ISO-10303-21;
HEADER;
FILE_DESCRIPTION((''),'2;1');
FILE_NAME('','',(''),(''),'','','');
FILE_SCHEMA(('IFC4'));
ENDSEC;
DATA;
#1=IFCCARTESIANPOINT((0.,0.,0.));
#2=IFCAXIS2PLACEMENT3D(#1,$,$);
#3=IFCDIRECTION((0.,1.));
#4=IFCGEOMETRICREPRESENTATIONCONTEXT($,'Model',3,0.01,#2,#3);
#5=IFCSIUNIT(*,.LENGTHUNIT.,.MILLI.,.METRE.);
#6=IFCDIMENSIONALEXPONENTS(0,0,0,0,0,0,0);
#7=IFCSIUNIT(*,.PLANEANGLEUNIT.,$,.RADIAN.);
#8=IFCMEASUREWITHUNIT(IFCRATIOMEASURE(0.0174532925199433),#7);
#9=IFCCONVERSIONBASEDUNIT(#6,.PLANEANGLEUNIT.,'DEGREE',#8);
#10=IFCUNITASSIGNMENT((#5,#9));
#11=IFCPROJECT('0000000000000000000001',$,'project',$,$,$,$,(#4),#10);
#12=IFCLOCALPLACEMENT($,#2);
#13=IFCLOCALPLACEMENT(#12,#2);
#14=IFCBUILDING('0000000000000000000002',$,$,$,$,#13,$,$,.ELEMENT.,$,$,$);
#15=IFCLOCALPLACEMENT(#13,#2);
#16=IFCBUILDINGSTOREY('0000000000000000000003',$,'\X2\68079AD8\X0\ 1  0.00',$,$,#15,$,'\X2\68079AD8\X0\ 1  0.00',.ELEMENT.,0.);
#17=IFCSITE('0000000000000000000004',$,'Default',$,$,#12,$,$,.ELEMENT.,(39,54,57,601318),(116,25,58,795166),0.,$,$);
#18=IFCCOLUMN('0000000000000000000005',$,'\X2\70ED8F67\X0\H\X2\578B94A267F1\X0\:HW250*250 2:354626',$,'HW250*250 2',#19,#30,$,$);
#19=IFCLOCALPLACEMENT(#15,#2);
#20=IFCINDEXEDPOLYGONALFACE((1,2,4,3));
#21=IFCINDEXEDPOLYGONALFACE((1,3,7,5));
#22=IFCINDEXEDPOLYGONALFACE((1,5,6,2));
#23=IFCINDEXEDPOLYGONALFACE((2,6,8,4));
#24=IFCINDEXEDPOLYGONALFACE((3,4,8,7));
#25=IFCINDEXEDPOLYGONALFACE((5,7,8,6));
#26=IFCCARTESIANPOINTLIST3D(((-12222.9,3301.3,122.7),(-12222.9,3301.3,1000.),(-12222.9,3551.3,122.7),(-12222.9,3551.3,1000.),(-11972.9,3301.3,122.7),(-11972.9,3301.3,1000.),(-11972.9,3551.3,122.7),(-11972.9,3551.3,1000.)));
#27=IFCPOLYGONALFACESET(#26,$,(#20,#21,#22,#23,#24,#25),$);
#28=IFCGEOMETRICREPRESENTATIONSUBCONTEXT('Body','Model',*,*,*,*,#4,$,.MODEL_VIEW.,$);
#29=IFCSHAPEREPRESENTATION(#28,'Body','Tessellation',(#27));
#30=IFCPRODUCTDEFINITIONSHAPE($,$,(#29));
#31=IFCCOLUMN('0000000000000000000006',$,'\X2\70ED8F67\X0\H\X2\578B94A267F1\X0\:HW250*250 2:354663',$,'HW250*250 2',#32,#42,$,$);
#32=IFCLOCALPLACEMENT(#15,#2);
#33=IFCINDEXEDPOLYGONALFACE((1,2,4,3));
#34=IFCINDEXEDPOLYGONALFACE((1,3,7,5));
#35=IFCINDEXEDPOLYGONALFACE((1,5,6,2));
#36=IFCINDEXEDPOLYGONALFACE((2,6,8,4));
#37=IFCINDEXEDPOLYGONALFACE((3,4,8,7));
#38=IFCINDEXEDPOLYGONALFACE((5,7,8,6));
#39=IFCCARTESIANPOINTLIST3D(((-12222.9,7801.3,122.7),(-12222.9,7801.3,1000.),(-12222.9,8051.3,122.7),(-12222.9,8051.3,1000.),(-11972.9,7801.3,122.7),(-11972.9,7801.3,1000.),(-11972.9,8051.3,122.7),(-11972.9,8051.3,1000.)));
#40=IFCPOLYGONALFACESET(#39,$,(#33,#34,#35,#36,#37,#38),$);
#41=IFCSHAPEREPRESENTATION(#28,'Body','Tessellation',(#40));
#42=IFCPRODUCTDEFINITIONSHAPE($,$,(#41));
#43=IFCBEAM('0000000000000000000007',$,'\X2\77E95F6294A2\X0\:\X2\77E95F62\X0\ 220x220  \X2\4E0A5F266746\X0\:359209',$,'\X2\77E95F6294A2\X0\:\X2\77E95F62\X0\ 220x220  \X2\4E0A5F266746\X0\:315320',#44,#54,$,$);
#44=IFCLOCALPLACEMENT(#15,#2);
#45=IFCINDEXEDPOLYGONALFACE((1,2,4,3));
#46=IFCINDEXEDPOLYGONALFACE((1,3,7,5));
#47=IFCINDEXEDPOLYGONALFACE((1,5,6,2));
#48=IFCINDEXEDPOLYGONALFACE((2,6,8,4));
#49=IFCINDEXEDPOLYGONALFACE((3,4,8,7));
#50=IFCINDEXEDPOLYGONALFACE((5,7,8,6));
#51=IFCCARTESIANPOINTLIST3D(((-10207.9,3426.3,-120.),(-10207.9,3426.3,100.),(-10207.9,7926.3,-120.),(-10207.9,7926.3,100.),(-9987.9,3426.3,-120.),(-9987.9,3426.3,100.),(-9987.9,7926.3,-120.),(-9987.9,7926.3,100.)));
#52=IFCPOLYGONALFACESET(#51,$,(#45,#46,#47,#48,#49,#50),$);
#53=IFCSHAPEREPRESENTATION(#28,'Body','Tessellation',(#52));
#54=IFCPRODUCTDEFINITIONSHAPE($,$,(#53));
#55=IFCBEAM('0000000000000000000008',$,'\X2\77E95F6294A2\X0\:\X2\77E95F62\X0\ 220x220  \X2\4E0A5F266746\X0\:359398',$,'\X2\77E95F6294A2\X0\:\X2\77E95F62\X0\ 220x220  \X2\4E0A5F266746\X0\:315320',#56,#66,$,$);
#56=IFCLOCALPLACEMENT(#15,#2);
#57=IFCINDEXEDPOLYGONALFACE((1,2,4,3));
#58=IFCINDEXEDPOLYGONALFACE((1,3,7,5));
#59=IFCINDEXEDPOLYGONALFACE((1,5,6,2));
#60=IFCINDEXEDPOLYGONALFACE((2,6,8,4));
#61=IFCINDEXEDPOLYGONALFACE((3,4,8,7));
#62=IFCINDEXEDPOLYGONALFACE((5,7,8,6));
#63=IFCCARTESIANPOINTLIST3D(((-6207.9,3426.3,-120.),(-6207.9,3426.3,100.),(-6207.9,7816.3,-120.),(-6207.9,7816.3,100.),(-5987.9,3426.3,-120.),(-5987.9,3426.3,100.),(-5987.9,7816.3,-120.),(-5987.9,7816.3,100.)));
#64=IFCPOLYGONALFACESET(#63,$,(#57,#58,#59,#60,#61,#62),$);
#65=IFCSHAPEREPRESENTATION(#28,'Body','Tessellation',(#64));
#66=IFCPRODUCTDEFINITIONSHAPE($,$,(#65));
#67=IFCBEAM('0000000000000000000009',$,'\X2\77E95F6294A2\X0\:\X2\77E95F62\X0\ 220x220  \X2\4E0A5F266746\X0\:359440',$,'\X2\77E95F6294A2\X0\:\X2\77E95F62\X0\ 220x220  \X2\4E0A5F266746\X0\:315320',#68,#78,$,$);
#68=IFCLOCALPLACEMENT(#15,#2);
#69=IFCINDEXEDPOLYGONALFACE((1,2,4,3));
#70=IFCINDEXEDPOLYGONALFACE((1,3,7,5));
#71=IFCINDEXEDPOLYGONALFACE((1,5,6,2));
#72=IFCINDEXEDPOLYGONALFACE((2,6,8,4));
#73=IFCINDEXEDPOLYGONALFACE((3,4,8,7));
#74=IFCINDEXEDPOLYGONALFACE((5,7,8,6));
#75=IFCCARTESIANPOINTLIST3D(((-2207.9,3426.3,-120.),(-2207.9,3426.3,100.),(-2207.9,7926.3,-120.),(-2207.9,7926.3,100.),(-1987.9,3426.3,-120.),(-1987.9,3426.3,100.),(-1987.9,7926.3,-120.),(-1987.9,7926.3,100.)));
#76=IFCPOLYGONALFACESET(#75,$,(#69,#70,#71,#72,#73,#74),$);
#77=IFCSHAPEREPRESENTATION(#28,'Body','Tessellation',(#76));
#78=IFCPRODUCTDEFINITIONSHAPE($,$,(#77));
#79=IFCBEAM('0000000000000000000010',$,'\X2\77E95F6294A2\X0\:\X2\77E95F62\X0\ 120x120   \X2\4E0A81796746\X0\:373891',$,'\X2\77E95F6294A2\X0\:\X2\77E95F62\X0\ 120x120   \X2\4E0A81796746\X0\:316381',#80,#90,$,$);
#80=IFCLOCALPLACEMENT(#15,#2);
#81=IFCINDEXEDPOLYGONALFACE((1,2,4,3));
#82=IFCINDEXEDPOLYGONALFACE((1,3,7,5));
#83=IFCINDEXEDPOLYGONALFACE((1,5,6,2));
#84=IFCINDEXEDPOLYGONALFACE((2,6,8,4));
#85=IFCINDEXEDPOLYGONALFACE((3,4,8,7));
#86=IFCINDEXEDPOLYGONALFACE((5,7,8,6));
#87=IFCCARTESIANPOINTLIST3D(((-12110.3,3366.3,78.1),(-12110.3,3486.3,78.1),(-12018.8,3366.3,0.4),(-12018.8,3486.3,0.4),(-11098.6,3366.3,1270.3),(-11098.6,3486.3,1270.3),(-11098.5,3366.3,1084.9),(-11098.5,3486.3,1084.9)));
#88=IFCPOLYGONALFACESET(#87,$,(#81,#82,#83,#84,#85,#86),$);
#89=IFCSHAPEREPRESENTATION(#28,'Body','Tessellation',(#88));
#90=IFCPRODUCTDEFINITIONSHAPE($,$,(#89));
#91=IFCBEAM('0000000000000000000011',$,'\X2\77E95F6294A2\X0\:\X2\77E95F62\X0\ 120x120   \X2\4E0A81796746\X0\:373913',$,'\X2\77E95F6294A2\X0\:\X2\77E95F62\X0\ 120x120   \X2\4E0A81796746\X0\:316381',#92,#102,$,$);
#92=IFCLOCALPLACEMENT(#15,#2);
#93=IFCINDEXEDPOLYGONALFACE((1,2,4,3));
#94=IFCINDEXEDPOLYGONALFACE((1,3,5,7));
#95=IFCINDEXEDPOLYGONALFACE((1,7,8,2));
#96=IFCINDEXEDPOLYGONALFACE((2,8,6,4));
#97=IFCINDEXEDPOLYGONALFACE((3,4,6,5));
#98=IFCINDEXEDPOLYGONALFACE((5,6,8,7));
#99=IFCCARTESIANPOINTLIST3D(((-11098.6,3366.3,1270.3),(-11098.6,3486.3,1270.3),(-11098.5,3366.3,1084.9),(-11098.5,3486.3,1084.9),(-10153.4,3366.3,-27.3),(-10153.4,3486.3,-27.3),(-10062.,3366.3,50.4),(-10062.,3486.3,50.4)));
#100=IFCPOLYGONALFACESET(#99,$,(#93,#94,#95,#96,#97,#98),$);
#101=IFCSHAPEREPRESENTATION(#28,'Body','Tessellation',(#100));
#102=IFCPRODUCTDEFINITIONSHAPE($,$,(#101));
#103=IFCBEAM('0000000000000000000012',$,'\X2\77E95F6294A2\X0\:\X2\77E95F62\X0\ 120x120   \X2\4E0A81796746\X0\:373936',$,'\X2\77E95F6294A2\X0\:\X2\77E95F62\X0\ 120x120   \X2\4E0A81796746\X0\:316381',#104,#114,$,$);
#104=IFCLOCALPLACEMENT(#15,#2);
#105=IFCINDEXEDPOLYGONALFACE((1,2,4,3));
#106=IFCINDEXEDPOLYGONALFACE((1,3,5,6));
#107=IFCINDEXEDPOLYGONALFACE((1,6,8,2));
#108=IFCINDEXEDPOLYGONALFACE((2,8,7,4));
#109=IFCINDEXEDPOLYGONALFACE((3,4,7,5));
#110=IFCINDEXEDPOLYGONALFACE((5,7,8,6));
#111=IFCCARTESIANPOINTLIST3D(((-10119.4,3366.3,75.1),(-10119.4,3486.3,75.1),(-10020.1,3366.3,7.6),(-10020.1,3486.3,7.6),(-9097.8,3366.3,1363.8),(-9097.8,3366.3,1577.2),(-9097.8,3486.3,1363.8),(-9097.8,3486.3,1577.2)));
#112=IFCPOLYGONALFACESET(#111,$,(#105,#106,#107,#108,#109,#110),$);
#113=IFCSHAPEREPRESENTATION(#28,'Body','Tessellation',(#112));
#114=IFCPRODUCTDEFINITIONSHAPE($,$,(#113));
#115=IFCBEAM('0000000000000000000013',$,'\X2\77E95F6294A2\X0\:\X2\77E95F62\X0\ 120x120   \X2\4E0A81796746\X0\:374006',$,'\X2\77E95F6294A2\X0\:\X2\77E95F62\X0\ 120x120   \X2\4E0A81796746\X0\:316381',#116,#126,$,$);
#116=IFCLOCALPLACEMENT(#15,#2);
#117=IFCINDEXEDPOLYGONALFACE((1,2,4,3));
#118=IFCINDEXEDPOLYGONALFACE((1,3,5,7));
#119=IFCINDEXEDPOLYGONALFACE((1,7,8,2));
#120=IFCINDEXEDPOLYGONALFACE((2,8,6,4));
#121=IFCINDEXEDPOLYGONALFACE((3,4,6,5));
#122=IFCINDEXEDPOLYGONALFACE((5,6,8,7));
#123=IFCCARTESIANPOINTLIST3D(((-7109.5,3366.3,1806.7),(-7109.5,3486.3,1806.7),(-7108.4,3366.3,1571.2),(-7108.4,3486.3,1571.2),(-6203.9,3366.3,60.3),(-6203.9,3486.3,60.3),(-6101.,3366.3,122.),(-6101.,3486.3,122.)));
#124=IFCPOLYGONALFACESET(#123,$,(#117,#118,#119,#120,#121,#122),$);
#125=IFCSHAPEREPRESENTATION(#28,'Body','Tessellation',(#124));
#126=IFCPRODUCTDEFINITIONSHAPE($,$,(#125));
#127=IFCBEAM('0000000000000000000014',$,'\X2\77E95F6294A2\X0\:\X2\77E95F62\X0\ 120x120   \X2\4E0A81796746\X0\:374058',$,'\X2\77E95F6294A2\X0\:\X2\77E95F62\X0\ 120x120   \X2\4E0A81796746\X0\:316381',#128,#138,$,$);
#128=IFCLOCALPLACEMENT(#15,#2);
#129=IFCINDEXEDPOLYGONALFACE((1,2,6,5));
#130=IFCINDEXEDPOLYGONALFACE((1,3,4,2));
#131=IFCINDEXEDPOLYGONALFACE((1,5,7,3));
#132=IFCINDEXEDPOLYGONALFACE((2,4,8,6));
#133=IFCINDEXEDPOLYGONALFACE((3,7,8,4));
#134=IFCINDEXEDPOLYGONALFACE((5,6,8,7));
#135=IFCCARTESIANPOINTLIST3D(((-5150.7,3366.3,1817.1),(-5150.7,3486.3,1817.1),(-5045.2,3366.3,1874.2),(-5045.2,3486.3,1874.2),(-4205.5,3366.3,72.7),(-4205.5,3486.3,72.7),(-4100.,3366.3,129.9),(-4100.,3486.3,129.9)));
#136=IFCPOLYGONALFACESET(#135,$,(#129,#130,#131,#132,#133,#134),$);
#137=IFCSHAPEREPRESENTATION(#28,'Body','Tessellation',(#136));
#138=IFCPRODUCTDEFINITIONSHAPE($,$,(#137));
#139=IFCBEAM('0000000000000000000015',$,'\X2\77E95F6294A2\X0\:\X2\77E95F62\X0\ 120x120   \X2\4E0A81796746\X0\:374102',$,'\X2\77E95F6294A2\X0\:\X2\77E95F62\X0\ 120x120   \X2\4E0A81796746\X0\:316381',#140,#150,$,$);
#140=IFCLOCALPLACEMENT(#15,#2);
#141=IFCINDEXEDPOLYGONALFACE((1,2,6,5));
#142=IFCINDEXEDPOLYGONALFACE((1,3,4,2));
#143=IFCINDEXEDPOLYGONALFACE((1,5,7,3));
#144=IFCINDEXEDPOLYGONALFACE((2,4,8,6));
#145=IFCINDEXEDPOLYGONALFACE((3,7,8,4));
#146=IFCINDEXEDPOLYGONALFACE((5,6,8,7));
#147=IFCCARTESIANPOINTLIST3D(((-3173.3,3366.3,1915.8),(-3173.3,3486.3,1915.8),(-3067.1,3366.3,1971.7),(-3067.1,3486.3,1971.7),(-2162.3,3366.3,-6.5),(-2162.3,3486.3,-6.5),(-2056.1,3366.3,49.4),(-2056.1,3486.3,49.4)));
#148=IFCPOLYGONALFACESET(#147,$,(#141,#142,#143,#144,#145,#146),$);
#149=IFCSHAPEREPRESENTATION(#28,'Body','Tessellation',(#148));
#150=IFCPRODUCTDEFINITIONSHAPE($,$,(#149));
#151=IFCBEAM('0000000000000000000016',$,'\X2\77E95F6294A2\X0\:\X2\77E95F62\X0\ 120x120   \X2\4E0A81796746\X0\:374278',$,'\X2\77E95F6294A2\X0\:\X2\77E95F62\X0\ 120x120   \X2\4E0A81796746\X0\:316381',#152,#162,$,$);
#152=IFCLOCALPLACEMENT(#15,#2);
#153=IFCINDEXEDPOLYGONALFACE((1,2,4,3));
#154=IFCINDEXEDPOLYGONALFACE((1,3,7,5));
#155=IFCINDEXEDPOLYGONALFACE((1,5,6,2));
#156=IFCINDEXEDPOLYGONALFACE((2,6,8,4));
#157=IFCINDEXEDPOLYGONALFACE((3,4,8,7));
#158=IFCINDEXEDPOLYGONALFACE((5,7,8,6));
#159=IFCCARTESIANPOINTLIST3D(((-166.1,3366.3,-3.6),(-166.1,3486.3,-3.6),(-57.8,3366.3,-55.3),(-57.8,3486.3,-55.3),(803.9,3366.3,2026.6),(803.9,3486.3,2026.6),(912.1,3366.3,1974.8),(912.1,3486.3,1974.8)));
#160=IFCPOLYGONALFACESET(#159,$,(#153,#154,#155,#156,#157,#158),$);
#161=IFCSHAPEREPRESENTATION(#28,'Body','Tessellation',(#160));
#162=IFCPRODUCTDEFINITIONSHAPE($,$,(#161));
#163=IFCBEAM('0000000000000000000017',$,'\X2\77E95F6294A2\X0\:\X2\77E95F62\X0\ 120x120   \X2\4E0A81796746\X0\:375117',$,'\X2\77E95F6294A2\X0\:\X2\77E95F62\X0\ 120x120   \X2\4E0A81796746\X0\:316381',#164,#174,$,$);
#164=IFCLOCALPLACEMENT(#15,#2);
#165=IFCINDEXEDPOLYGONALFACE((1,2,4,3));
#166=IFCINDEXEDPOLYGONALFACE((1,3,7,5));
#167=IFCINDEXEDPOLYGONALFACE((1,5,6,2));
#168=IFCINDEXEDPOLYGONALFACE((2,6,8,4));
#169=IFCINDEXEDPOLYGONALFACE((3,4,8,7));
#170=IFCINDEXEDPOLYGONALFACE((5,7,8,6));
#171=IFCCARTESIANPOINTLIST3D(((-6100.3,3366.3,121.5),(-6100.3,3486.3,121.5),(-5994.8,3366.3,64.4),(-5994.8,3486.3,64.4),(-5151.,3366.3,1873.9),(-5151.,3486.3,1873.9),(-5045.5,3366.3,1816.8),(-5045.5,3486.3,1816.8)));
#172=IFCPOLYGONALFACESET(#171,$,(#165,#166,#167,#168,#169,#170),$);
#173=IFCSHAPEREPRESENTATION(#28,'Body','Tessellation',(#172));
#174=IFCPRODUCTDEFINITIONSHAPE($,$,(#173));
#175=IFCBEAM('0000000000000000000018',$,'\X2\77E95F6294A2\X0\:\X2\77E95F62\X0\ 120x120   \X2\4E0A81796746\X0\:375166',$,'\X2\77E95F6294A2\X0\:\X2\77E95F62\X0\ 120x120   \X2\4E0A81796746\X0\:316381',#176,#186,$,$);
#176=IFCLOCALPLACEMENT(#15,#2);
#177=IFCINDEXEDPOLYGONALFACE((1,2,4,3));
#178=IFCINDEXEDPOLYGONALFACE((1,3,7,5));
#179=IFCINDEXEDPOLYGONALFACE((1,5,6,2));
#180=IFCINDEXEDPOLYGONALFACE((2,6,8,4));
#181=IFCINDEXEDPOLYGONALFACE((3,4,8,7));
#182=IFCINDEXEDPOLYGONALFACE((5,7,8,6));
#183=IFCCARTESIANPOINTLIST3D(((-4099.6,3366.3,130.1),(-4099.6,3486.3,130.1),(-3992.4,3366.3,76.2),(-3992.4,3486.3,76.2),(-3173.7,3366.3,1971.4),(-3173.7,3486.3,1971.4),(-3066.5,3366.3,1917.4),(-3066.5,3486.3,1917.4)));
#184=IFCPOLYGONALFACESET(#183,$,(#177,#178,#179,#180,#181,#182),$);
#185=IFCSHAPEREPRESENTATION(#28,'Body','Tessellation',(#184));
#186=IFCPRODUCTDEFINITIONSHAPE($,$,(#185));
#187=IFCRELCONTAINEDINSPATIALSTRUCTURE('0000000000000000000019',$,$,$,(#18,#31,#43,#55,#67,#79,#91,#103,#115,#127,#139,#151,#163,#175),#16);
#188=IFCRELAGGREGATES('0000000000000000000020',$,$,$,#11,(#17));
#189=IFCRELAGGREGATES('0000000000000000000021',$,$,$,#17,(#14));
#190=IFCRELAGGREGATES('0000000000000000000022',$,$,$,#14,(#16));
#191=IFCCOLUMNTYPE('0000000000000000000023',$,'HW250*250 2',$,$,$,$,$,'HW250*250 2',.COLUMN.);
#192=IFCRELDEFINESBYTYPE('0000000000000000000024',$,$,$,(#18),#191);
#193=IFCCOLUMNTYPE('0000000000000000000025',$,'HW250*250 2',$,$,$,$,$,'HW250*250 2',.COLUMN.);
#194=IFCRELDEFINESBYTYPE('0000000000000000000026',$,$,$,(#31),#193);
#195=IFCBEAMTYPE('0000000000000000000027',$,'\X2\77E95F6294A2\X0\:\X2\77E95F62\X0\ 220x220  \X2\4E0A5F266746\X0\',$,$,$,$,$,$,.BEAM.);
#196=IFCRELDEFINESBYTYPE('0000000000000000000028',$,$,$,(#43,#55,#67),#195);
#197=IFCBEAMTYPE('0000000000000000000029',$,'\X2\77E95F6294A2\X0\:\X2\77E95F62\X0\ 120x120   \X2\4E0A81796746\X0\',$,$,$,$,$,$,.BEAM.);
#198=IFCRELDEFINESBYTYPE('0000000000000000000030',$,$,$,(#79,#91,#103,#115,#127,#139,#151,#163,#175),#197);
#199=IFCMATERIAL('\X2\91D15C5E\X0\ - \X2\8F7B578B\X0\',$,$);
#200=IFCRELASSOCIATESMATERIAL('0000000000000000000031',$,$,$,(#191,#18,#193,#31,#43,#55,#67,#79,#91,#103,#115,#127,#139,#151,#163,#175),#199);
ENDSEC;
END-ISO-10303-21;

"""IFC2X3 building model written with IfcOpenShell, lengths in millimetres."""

from ifc_helpers import new_model, entity, si_unit, converted_unit, direction, frame, frame_2d, origin, origin_2d_with_axis, place, context, subcontext, project, spatial, rectangle, extrude, clip, halfspace, source, transform, mapped, material, type_object, type_shapes, element, save


model = new_model("IFC2X3")

# Units and contexts
model_context = context("Model", 3, precision=0.01, world=origin(), true_north=direction((0.0, 1.0)))
body_context = subcontext(model_context, "Body", "Model", "MODEL_VIEW")
ifc_project = project(units=[si_unit("LENGTHUNIT", "METRE", prefix="MILLI"), converted_unit("PLANEANGLEUNIT", "DEGREE", entity("IfcRatioMeasure", 0.0174532925199433), si_unit("PLANEANGLEUNIT", "RADIAN"), dimensions=[0, 0, 0, 0, 0, 0, 0])], contexts=[model_context])

# Site, building, storey
site_placement = place(None, origin())
site = spatial("IfcSite", under=ifc_project, at=site_placement, Name="Default", CompositionType="ELEMENT", RefLatitude=(39, 54, 57, 601318), RefLongitude=(116, 25, 58, 795166), RefElevation=0.0)
building_placement = place(site_placement, origin())
building = spatial("IfcBuilding", under=site, at=building_placement, CompositionType="ELEMENT")
storey_placement = place(building_placement, origin())
storey = spatial("IfcBuildingStorey", under=building, at=storey_placement, Name="标高 1  0.00", LongName="标高 1  0.00", CompositionType="ELEMENT", Elevation=0.0)

# Columns
ifc_material_1 = material(Name="金属 - 轻型")
column_type_1 = type_object("IfcColumnType", Name="HW250*250 2", ElementType="HW250*250 2", PredefinedType="COLUMN", material=ifc_material_1)
shared_shape_1 = source(origin(), body_context, "Body", "SweptSolid", [
    extrude(rectangle(XDim=250.0, YDim=250.0, at=frame_2d((0.0, 0.0), x_axis=(1.0, 0.0))), frame((-12097.9, 3426.3, 122.7), z_axis=(0.0, 0.0, 1.0), x_axis=(0.0, -1.0, 0.0)), (0.0, 0.0, 1.0), 877.3),
])
type_shapes(column_type_1, [shared_shape_1])
column_1_placement = place(storey_placement, origin())
element("IfcColumn", 1, at=column_1_placement, inside=storey, type_object=column_type_1, material=ifc_material_1, Name="热轧H型钢柱:HW250*250 2:354626", ObjectType="HW250*250 2", context=body_context, shape_type="MappedRepresentation", body=[
    mapped(shared_shape_1, transform((0.0, 0.0, 0.0), scale=1.0)),
])
column_type_2 = type_object("IfcColumnType", Name="HW250*250 2", ElementType="HW250*250 2", PredefinedType="COLUMN", material=ifc_material_1)
shared_shape_2 = source(origin(), body_context, "Body", "SweptSolid", [
    extrude(rectangle(XDim=250.0, YDim=250.0, at=origin_2d_with_axis()), frame((-12097.9, 7926.3, 122.7), z_axis=(0.0, 0.0, 1.0), x_axis=(0.0, -1.0, 0.0)), (0.0, 0.0, 1.0), 877.3),
])
type_shapes(column_type_2, [shared_shape_2])
column_2_placement = place(storey_placement, origin())
element("IfcColumn", 2, at=column_2_placement, inside=storey, type_object=column_type_2, material=ifc_material_1, Name="热轧H型钢柱:HW250*250 2:354663", ObjectType="HW250*250 2", context=body_context, shape_type="MappedRepresentation", body=[
    mapped(shared_shape_2, transform((0.0, 0.0, 0.0), scale=1.0)),
])

# Beams
beam_type_1 = type_object("IfcBeamType", Name="矩形钢:矩形 220x220  上弦杆", PredefinedType="BEAM")
beam_1_placement = place(storey_placement, frame((-10097.9, 7926.3, -10.0), z_axis=(0.0, 0.0, 1.0), x_axis=(0.0, -1.0, 0.0)))
element("IfcBeam", 3, at=beam_1_placement, inside=storey, type_object=beam_type_1, material=ifc_material_1, Name="矩形钢:矩形 220x220  上弦杆:359209", ObjectType="矩形钢:矩形 220x220  上弦杆:315320", context=body_context, shape_type="SweptSolid", body=[
    extrude(rectangle(XDim=220.0, YDim=220.0, at=frame_2d((0.0, 0.0), x_axis=(1.0, 0.0))), frame((0.0, 0.0, 0.0), z_axis=(1.0, 0.0, 0.0), x_axis=(0.0, 0.0, -1.0)), (0.0, 0.0, 1.0), 4500.0),
])
beam_2_placement = place(storey_placement, frame((-6097.9, 7926.3, -10.0), z_axis=(0.0, 0.0, 1.0), x_axis=(0.0, -1.0, 0.0)))
element("IfcBeam", 4, at=beam_2_placement, inside=storey, type_object=beam_type_1, material=ifc_material_1, Name="矩形钢:矩形 220x220  上弦杆:359398", ObjectType="矩形钢:矩形 220x220  上弦杆:315320", context=body_context, shape_type="SweptSolid", body=[
    extrude(rectangle(XDim=220.0, YDim=220.0, at=frame_2d((0.0, 0.0), x_axis=(1.0, 0.0))), frame((110.0, 0.0, 0.0), z_axis=(1.0, 0.0, 0.0), x_axis=(0.0, 0.0, -1.0)), (0.0, 0.0, 1.0), 4390.0),
])
beam_3_placement = place(storey_placement, frame((-2097.9, 7926.3, -10.0), z_axis=(0.0, 0.0, 1.0), x_axis=(0.0, -1.0, 0.0)))
element("IfcBeam", 5, at=beam_3_placement, inside=storey, type_object=beam_type_1, material=ifc_material_1, Name="矩形钢:矩形 220x220  上弦杆:359440", ObjectType="矩形钢:矩形 220x220  上弦杆:315320", context=body_context, shape_type="SweptSolid", body=[
    extrude(rectangle(XDim=220.0, YDim=220.0, at=origin_2d_with_axis()), frame((0.0, 0.0, 0.0), z_axis=(1.0, 0.0, 0.0), x_axis=(0.0, 0.0, -1.0)), (0.0, 0.0, 1.0), 4500.0),
])
beam_type_2 = type_object("IfcBeamType", Name="矩形钢:矩形 120x120   上腹杆", PredefinedType="BEAM")
beam_4_placement = place(storey_placement, frame((-12097.9, 3426.3, 0.0), z_axis=(0.76245, 0.0, -0.647047), x_axis=(0.647047, 0.0, 0.76245)))
element("IfcBeam", 6, at=beam_4_placement, inside=storey, type_object=beam_type_2, material=ifc_material_1, Name="矩形钢:矩形 120x120   上腹杆:373891", ObjectType="矩形钢:矩形 120x120   上腹杆:316381", context=body_context, shape_type="Clipping", body=[
    clip(extrude(rectangle(XDim=120.0, YDim=120.0, at=frame_2d((0.0, 0.0), x_axis=(1.0, 0.0))), frame((51.5, 0.0, 0.0), z_axis=(1.0, 0.0, 0.0), x_axis=(0.0, 0.0, -1.0)), (0.0, 0.0, 1.0), 1563.7), halfspace(frame((1615.1, 0.0, -60.0), z_axis=(0.647294, 0.0, 0.762241), x_axis=(0.0, 1.0, 0.0)), False)),
])
beam_5_placement = place(storey_placement, frame((-11098.5, 3426.3, 1177.6), z_axis=(0.762031, 0.0, 0.647541), x_axis=(0.647541, 0.0, -0.762031)))
element("IfcBeam", 7, at=beam_5_placement, inside=storey, type_object=beam_type_2, material=ifc_material_1, Name="矩形钢:矩形 120x120   上腹杆:373913", ObjectType="矩形钢:矩形 120x120   上腹杆:316381", context=body_context, shape_type="Clipping", body=[
    clip(extrude(rectangle(XDim=120.0, YDim=120.0, at=frame_2d((0.0, 0.0), x_axis=(1.0, 0.0))), frame((-70.7, 0.0, 0.0), z_axis=(1.0, 0.0, 0.0), x_axis=(0.0, 0.0, -1.0)), (0.0, 0.0, 1.0), 1600.8), halfspace(frame((-70.7, 0.0, 60.0), z_axis=(-0.647294, 0.0, -0.762241), x_axis=(0.0, 1.0, 0.0)), False)),
])
beam_6_placement = place(storey_placement, frame((-10097.9, 3426.3, 0.0), z_axis=(0.826885, 0.0, -0.562371), x_axis=(0.562371, 0.0, 0.826885)))
element("IfcBeam", 8, at=beam_6_placement, inside=storey, type_object=beam_type_2, material=ifc_material_1, Name="矩形钢:矩形 120x120   上腹杆:373936", ObjectType="矩形钢:矩形 120x120   上腹杆:316381", context=body_context, shape_type="Clipping", body=[
    clip(extrude(rectangle(XDim=120.0, YDim=120.0, at=frame_2d((0.0, 0.0), x_axis=(1.0, 0.0))), frame((50.0, 0.0, 0.0), z_axis=(1.0, 0.0, 0.0), x_axis=(0.0, 0.0, -1.0)), (0.0, 0.0, 1.0), 1816.6), halfspace(frame((1866.6, 0.0, -60.0), z_axis=(0.562323, 0.0, 0.826918), x_axis=(0.0, 1.0, 0.0)), False)),
])
beam_7_placement = place(storey_placement, frame((-7108.9, 3426.3, 1689.0), z_axis=(0.858017, 0.0, 0.513621), x_axis=(0.513621, 0.0, -0.858017)))
element("IfcBeam", 9, at=beam_7_placement, inside=storey, type_object=beam_type_2, material=ifc_material_1, Name="矩形钢:矩形 120x120   上腹杆:374006", ObjectType="矩形钢:矩形 120x120   上腹杆:316381", context=body_context, shape_type="Clipping", body=[
    clip(extrude(rectangle(XDim=120.0, YDim=120.0, at=frame_2d((0.0, 0.0), x_axis=(1.0, 0.0))), frame((-101.3, 0.0, 0.0), z_axis=(1.0, 0.0, 0.0), x_axis=(0.0, 0.0, -1.0)), (0.0, 0.0, 1.0), 1963.6), halfspace(frame((-101.3, 0.0, 60.0), z_axis=(-0.509462, 0.0, -0.860493), x_axis=(0.860493, 0.0, -0.509462)), False)),
])
beam_8_placement = place(storey_placement, frame((-5098.0, 3426.3, 1845.8), z_axis=(0.879226, 0.0, 0.476405), x_axis=(0.476405, 0.0, -0.879226)))
element("IfcBeam", 10, at=beam_8_placement, inside=storey, type_object=beam_type_2, material=ifc_material_1, Name="矩形钢:矩形 120x120   上腹杆:374058", ObjectType="矩形钢:矩形 120x120   上腹杆:316381", context=body_context, shape_type="SweptSolid", body=[
    extrude(rectangle(XDim=120.0, YDim=120.0, at=frame_2d((0.0, 0.0), x_axis=(1.0, 0.0))), frame((0.2, 0.0, 0.0), z_axis=(1.0, 0.0, 0.0), x_axis=(0.0, 0.0, -1.0)), (0.0, 0.0, 1.0), 1984.0),
])
beam_9_placement = place(storey_placement, frame((-3120.3, 3426.3, 1944.0), z_axis=(0.885052, 0.0, 0.465492), x_axis=(0.465492, 0.0, -0.885052)))
element("IfcBeam", 11, at=beam_9_placement, inside=storey, type_object=beam_type_2, material=ifc_material_1, Name="矩形钢:矩形 120x120   上腹杆:374102", ObjectType="矩形钢:矩形 120x120   上腹杆:316381", context=body_context, shape_type="SweptSolid", body=[
    extrude(rectangle(XDim=120.0, YDim=120.0, at=frame_2d((0.0, 0.0), x_axis=(1.0, 0.0))), frame((0.2, 0.0, 0.0), z_axis=(1.0, 0.0, 0.0), x_axis=(0.0, 0.0, -1.0)), (0.0, 0.0, 1.0), 2172.0),
])
beam_10_placement = place(storey_placement, frame((-97.9, 3426.3, 0.0), z_axis=(0.902304, 0.0, -0.431101), x_axis=(0.431101, 0.0, 0.902304)))
element("IfcBeam", 12, at=beam_10_placement, inside=storey, type_object=beam_type_2, material=ifc_material_1, Name="矩形钢:矩形 120x120   上腹杆:374278", ObjectType="矩形钢:矩形 120x120   上腹杆:316381", context=body_context, shape_type="SweptSolid", body=[
    extrude(rectangle(XDim=120.0, YDim=120.0, at=frame_2d((0.0, 0.0), x_axis=(1.0, 0.0))), frame((-32.7, 0.0, 0.0), z_axis=(1.0, 0.0, 0.0), x_axis=(0.0, 0.0, -1.0)), (0.0, 0.0, 1.0), 2250.0),
])
beam_11_placement = place(storey_placement, frame((-5097.9, 3426.3, 1846.0), z_axis=(0.879282, 0.0, -0.476301), x_axis=(-0.476301, 0.0, -0.879282)))
element("IfcBeam", 13, at=beam_11_placement, inside=storey, type_object=beam_type_2, material=ifc_material_1, Name="矩形钢:矩形 120x120   上腹杆:375117", ObjectType="矩形钢:矩形 120x120   上腹杆:316381", context=body_context, shape_type="SweptSolid", body=[
    extrude(rectangle(XDim=120.0, YDim=120.0, at=frame_2d((0.0, 0.0), x_axis=(1.0, 0.0))), frame((0.7, 0.0, 0.0), z_axis=(1.0, 0.0, 0.0), x_axis=(0.0, 0.0, -1.0)), (0.0, 0.0, 1.0), 1993.0),
])
beam_12_placement = place(storey_placement, frame((-3120.3, 3426.3, 1943.9), z_axis=(0.893396, 0.0, -0.449271), x_axis=(-0.449271, 0.0, -0.893396)))
element("IfcBeam", 14, at=beam_12_placement, inside=storey, type_object=beam_type_2, material=ifc_material_1, Name="矩形钢:矩形 120x120   上腹杆:375166", ObjectType="矩形钢:矩形 120x120   上腹杆:316381", context=body_context, shape_type="SweptSolid", body=[
    extrude(rectangle(XDim=120.0, YDim=120.0, at=frame_2d((0.0, 0.0), x_axis=(1.0, 0.0))), frame((-0.6, 0.0, 0.0), z_axis=(1.0, 0.0, 0.0), x_axis=(0.0, 0.0, -1.0)), (0.0, 0.0, 1.0), 2061.0),
])

save(model, "model.ifc")
